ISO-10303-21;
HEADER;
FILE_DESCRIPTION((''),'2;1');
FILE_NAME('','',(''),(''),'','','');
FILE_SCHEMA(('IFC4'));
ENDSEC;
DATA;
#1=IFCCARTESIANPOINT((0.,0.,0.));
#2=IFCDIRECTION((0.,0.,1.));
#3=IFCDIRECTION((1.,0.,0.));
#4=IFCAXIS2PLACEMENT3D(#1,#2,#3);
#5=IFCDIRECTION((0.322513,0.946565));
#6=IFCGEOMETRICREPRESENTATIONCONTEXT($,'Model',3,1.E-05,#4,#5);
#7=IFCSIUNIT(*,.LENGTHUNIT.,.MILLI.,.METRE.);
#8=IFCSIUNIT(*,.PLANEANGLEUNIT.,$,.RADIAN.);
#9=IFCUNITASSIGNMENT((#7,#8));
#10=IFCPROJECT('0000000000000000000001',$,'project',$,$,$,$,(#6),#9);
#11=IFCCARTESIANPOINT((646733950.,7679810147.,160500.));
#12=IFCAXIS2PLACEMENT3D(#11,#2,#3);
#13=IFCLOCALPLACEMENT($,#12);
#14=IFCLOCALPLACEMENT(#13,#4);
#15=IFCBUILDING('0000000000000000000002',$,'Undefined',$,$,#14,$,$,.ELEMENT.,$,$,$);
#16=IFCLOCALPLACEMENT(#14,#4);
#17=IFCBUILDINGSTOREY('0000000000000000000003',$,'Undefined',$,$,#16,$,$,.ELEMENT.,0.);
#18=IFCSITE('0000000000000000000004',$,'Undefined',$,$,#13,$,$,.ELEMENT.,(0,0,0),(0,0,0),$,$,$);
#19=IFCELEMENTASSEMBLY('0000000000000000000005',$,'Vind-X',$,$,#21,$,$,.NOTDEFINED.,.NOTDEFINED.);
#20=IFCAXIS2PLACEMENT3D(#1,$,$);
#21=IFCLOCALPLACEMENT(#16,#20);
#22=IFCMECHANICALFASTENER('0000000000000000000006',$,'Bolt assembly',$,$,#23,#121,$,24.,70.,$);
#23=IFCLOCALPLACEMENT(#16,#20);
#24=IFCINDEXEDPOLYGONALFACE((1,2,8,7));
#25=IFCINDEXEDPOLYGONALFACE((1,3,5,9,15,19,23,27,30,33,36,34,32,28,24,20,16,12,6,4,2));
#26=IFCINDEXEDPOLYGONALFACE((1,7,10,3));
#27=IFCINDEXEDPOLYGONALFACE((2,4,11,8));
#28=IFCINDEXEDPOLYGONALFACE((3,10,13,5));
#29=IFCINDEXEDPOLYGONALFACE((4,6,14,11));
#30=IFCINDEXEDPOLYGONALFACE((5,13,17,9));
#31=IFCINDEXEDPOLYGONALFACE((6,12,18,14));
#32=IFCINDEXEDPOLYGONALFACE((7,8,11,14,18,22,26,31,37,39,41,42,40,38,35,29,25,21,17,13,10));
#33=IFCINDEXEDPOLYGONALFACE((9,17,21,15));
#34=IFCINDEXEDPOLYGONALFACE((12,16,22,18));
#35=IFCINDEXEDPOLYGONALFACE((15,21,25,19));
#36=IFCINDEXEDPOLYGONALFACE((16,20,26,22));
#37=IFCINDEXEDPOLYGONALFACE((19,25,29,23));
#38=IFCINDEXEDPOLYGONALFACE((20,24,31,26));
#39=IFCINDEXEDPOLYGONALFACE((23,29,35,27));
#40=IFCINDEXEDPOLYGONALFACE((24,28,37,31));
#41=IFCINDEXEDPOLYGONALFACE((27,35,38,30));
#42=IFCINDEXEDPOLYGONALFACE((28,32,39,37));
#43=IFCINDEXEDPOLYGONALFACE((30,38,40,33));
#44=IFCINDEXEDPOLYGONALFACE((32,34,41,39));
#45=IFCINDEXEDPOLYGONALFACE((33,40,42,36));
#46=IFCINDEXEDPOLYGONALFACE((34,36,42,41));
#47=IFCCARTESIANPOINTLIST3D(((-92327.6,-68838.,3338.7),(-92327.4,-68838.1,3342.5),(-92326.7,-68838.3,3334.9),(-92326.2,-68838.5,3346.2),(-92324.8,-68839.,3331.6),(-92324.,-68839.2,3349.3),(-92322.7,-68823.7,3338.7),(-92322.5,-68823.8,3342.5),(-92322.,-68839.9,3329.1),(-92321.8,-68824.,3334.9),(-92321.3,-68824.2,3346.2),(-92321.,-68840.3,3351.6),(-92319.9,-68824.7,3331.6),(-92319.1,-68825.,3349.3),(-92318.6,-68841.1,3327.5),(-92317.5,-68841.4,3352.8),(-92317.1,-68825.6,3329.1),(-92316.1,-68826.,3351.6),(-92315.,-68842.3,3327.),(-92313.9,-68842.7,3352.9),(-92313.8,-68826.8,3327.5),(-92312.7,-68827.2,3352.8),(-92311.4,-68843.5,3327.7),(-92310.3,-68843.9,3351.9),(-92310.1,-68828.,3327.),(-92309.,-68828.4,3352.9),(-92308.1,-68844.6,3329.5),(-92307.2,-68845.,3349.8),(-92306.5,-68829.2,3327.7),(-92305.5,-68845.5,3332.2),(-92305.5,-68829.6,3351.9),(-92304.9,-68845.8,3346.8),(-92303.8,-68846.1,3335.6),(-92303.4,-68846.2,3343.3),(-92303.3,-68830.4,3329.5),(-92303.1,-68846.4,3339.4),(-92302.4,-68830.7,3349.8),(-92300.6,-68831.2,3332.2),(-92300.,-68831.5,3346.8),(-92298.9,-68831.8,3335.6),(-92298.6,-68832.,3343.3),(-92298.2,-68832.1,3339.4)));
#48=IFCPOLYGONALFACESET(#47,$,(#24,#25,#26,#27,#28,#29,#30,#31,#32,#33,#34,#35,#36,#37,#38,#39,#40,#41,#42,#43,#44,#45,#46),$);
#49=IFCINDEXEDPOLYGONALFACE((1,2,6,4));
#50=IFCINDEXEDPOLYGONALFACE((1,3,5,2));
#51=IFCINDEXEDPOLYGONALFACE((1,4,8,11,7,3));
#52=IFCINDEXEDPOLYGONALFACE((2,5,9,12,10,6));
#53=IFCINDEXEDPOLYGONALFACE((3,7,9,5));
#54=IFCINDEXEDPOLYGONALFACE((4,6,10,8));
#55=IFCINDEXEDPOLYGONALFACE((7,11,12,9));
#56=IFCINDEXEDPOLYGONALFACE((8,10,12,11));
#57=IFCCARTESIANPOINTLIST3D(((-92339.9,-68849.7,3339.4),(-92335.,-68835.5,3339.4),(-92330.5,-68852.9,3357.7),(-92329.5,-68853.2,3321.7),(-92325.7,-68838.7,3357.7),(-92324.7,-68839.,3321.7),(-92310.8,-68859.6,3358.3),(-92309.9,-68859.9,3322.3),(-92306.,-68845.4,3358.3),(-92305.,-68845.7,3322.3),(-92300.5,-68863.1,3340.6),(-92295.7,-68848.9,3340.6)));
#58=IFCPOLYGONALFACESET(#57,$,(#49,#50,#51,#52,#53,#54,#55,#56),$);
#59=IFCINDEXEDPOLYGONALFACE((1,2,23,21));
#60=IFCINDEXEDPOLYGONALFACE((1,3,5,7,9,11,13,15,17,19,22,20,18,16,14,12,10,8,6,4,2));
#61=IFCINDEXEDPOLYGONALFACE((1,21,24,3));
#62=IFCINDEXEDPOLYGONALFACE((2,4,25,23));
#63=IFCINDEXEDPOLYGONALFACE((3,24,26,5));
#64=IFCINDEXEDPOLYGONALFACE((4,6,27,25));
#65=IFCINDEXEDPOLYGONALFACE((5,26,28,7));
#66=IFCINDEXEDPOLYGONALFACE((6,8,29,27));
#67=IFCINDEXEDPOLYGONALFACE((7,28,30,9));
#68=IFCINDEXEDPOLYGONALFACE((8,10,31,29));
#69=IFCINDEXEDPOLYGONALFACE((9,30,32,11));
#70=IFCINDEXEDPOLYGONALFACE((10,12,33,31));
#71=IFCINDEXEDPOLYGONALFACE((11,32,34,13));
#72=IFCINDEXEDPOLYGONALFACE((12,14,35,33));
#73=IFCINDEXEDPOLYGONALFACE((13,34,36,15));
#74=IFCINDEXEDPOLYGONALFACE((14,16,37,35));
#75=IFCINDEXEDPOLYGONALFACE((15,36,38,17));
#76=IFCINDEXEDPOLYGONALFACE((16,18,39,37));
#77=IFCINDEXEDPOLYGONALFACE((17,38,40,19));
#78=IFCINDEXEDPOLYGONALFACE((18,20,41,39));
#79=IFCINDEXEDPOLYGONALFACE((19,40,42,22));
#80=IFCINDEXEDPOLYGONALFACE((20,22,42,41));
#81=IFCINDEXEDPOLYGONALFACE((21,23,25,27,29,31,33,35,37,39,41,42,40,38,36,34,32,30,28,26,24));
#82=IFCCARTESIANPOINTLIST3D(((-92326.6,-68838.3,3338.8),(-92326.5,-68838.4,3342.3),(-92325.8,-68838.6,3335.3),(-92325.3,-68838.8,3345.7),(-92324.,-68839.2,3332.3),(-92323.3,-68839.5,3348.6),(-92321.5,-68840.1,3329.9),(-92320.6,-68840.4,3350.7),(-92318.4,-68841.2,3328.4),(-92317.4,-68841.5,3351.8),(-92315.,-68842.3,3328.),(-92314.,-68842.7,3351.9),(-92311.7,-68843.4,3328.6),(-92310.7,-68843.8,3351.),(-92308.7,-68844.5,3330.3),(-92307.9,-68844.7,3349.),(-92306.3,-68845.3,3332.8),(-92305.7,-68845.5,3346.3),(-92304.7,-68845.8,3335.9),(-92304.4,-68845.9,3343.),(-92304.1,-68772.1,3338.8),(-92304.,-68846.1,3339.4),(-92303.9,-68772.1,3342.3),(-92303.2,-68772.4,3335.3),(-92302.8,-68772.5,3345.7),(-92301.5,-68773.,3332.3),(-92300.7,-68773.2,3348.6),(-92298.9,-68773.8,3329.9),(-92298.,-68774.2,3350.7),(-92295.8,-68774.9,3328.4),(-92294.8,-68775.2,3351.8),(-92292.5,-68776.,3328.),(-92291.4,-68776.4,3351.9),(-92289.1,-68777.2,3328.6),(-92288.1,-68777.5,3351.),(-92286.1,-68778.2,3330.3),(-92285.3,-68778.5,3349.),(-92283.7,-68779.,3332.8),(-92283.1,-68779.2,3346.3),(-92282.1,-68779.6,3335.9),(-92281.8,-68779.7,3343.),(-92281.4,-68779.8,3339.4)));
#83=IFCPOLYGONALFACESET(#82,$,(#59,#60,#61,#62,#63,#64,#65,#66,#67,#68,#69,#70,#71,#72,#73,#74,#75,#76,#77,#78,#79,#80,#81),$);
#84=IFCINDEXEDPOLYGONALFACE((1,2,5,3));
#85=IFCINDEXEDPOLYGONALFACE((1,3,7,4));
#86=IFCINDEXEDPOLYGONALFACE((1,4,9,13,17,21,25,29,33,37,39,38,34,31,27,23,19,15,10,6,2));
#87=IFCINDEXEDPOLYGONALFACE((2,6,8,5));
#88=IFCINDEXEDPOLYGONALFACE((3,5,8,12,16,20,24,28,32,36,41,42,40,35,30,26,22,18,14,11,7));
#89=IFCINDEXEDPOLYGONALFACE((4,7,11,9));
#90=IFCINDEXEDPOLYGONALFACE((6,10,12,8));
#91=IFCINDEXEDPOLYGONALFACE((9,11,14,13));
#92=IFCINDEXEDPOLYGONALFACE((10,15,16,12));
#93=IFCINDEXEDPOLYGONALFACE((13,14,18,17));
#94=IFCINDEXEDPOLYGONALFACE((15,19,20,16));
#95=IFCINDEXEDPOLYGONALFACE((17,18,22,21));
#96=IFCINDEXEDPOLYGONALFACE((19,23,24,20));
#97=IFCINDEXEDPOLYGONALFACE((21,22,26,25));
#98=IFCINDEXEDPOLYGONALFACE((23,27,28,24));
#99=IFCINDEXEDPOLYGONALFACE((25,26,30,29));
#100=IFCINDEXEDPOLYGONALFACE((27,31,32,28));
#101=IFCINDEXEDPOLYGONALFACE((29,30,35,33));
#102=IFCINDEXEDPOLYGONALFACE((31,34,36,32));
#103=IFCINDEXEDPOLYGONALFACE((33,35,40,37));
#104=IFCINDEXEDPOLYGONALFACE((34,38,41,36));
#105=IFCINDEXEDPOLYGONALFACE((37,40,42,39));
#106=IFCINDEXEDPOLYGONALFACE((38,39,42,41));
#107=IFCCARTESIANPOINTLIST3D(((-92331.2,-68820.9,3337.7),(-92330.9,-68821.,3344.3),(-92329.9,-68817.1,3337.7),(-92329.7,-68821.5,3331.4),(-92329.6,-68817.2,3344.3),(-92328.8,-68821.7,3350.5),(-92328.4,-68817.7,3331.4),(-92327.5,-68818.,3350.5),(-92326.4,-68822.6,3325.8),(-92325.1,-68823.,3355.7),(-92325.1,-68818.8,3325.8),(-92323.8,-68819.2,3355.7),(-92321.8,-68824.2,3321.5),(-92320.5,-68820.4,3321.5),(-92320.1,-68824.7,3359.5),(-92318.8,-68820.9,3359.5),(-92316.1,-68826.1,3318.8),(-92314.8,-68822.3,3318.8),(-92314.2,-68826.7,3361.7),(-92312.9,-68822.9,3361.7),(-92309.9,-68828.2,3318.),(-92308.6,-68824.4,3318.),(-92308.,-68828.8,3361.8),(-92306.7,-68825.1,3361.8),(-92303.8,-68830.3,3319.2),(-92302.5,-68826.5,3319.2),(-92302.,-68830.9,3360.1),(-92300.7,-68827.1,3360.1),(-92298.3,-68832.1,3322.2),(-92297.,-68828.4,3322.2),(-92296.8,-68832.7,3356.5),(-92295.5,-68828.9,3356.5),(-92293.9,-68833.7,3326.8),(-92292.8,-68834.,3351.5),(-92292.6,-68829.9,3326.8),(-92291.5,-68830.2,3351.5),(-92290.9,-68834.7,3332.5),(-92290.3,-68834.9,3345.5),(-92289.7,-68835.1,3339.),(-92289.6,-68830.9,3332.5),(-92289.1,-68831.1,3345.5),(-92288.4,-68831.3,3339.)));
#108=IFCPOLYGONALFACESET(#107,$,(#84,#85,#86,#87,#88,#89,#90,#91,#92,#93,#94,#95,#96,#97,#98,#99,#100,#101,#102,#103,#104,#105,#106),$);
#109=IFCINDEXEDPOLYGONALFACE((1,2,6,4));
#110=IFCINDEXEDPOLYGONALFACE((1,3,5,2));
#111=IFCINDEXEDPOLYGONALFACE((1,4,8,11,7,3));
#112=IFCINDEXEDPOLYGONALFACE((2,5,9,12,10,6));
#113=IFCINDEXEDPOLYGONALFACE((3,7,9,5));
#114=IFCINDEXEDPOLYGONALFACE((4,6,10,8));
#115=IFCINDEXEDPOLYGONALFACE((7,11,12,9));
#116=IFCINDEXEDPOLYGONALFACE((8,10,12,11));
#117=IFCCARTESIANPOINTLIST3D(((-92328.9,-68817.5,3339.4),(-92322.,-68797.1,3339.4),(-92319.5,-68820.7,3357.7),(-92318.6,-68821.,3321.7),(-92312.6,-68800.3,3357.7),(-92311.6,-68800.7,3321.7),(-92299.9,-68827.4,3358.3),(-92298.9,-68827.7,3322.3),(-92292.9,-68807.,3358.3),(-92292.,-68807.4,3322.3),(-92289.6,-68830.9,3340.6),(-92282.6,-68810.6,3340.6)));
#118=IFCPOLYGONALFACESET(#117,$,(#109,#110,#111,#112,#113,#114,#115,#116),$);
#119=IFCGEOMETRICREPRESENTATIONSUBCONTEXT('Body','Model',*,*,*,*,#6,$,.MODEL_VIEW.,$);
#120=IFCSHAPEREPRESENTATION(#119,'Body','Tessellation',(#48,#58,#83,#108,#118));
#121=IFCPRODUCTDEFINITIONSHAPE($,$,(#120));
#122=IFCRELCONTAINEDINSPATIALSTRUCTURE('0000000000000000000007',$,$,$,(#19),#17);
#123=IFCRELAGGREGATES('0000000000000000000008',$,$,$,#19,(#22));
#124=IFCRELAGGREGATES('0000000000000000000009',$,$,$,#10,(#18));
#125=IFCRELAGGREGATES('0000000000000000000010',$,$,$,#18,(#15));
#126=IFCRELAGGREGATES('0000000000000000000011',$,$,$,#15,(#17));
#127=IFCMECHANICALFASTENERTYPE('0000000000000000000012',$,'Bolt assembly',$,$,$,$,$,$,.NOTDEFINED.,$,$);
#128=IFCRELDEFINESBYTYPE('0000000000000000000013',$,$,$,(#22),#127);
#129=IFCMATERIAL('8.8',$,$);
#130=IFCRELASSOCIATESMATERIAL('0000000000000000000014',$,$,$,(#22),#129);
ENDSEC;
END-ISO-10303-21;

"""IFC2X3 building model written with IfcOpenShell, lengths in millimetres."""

from ifc_helpers import new_model, si_unit, direction, frame, origin_with_axes, origin_2d_with_axis, place, context, subcontext, project, spatial, polyline, circle, outline, extrude, source, transform, mapped, material, type_object, element, aggregate, save


model = new_model("IFC2X3")

# Units and contexts
model_context = context("Model", 3, precision=1e-05, world=origin_with_axes(), true_north=direction((0.322513, 0.946565)))
body_context = subcontext(model_context, "Body", "Model", "MODEL_VIEW")
ifc_project = project(units=[si_unit("LENGTHUNIT", "METRE", prefix="MILLI"), si_unit("PLANEANGLEUNIT", "RADIAN")], contexts=[model_context])

# Site, building, storey
site_placement = place(None, frame((646733950.0, 7679810147.0, 160500.0), z_axis=(0.0, 0.0, 1.0), x_axis=(1.0, 0.0, 0.0)))
site = spatial("IfcSite", under=ifc_project, at=site_placement, Name="Undefined", CompositionType="ELEMENT", RefLatitude=(0, 0, 0), RefLongitude=(0, 0, 0))
building_placement = place(site_placement, origin_with_axes())
building = spatial("IfcBuilding", under=site, at=building_placement, Name="Undefined", CompositionType="ELEMENT")
storey_placement = place(building_placement, origin_with_axes())
storey = spatial("IfcBuildingStorey", under=building, at=storey_placement, Name="Undefined", CompositionType="ELEMENT", Elevation=0.0)

# Shared definitions
ifc_material_1 = material(Name="8.8")
mechanical_fastener_type = type_object("IfcMechanicalFastenerType", Name="Bolt assembly")
shared_shape_1 = source(origin_with_axes(), body_context, "Body", "SweptSolid", [
    extrude(circle(Radius=13.0, at=origin_2d_with_axis()), frame((0.0, 0.0, 0.0), z_axis=(0.0, 1.0, 0.0), x_axis=(1.0, 0.0, 0.0)), (0.0, 0.0, 1.0), 15.1),
    extrude(outline(polyline([(18.0, -10.4), (18.0, 10.4), (0.0, 20.8), (-18.0, 10.4), (-18.0, -10.4), (0.0, -20.8), (18.0, -10.4)])), frame((0.0, -15.0, 0.0), z_axis=(0.0, 1.0, 0.0), x_axis=(1.0, 0.0, 0.0)), (0.0, 0.0, 1.0), 15.0),
    extrude(circle(Radius=12.0, at=origin_2d_with_axis()), frame((0.0, 0.0, 0.0), z_axis=(0.0, 1.0, 0.0), x_axis=(1.0, 0.0, 0.0)), (0.0, 0.0, 1.0), 70.0),
    extrude(circle(Radius=22.0, at=origin_2d_with_axis()), frame((0.0, 15.0, 0.0), z_axis=(0.0, 1.0, 0.0), x_axis=(1.0, 0.0, 0.0)), (0.0, 0.0, 1.0), 4.0),
    extrude(outline(polyline([(18.0, -10.4), (18.0, 10.4), (0.0, 20.8), (-18.0, 10.4), (-18.0, -10.4), (0.0, -20.8), (18.0, -10.4)])), frame((0.0, 19.0, 0.0), z_axis=(0.0, 1.0, 0.0), x_axis=(1.0, 0.0, 0.0)), (0.0, 0.0, 1.0), 21.5),
])

# Element assembly, mechanical fastener
assembly_1_placement = place(storey_placement, origin_with_axes())
assembly_1 = element("IfcElementAssembly", 1, at=assembly_1_placement, inside=storey, Name="Vind-X", AssemblyPlace="NOTDEFINED", PredefinedType="NOTDEFINED")
mechanical_fastener_1_placement = place(assembly_1_placement, frame((-92315.4, -68842.2, 3340.0), z_axis=(-0.450012, 0.153328, -0.879761), x_axis=(-0.832751, 0.283734, 0.475416)))
mechanical_fastener_1 = element("IfcMechanicalFastener", 2, at=mechanical_fastener_1_placement, type_object=mechanical_fastener_type, material=ifc_material_1, Name="Bolt assembly", NominalDiameter=24.0, NominalLength=70.0, context=body_context, shape_type="MappedRepresentation", body=[
    mapped(shared_shape_1, transform((0.0, 0.0, 0.0))),
])
aggregate(assembly_1, [mechanical_fastener_1])

save(model, "model.ifc")
